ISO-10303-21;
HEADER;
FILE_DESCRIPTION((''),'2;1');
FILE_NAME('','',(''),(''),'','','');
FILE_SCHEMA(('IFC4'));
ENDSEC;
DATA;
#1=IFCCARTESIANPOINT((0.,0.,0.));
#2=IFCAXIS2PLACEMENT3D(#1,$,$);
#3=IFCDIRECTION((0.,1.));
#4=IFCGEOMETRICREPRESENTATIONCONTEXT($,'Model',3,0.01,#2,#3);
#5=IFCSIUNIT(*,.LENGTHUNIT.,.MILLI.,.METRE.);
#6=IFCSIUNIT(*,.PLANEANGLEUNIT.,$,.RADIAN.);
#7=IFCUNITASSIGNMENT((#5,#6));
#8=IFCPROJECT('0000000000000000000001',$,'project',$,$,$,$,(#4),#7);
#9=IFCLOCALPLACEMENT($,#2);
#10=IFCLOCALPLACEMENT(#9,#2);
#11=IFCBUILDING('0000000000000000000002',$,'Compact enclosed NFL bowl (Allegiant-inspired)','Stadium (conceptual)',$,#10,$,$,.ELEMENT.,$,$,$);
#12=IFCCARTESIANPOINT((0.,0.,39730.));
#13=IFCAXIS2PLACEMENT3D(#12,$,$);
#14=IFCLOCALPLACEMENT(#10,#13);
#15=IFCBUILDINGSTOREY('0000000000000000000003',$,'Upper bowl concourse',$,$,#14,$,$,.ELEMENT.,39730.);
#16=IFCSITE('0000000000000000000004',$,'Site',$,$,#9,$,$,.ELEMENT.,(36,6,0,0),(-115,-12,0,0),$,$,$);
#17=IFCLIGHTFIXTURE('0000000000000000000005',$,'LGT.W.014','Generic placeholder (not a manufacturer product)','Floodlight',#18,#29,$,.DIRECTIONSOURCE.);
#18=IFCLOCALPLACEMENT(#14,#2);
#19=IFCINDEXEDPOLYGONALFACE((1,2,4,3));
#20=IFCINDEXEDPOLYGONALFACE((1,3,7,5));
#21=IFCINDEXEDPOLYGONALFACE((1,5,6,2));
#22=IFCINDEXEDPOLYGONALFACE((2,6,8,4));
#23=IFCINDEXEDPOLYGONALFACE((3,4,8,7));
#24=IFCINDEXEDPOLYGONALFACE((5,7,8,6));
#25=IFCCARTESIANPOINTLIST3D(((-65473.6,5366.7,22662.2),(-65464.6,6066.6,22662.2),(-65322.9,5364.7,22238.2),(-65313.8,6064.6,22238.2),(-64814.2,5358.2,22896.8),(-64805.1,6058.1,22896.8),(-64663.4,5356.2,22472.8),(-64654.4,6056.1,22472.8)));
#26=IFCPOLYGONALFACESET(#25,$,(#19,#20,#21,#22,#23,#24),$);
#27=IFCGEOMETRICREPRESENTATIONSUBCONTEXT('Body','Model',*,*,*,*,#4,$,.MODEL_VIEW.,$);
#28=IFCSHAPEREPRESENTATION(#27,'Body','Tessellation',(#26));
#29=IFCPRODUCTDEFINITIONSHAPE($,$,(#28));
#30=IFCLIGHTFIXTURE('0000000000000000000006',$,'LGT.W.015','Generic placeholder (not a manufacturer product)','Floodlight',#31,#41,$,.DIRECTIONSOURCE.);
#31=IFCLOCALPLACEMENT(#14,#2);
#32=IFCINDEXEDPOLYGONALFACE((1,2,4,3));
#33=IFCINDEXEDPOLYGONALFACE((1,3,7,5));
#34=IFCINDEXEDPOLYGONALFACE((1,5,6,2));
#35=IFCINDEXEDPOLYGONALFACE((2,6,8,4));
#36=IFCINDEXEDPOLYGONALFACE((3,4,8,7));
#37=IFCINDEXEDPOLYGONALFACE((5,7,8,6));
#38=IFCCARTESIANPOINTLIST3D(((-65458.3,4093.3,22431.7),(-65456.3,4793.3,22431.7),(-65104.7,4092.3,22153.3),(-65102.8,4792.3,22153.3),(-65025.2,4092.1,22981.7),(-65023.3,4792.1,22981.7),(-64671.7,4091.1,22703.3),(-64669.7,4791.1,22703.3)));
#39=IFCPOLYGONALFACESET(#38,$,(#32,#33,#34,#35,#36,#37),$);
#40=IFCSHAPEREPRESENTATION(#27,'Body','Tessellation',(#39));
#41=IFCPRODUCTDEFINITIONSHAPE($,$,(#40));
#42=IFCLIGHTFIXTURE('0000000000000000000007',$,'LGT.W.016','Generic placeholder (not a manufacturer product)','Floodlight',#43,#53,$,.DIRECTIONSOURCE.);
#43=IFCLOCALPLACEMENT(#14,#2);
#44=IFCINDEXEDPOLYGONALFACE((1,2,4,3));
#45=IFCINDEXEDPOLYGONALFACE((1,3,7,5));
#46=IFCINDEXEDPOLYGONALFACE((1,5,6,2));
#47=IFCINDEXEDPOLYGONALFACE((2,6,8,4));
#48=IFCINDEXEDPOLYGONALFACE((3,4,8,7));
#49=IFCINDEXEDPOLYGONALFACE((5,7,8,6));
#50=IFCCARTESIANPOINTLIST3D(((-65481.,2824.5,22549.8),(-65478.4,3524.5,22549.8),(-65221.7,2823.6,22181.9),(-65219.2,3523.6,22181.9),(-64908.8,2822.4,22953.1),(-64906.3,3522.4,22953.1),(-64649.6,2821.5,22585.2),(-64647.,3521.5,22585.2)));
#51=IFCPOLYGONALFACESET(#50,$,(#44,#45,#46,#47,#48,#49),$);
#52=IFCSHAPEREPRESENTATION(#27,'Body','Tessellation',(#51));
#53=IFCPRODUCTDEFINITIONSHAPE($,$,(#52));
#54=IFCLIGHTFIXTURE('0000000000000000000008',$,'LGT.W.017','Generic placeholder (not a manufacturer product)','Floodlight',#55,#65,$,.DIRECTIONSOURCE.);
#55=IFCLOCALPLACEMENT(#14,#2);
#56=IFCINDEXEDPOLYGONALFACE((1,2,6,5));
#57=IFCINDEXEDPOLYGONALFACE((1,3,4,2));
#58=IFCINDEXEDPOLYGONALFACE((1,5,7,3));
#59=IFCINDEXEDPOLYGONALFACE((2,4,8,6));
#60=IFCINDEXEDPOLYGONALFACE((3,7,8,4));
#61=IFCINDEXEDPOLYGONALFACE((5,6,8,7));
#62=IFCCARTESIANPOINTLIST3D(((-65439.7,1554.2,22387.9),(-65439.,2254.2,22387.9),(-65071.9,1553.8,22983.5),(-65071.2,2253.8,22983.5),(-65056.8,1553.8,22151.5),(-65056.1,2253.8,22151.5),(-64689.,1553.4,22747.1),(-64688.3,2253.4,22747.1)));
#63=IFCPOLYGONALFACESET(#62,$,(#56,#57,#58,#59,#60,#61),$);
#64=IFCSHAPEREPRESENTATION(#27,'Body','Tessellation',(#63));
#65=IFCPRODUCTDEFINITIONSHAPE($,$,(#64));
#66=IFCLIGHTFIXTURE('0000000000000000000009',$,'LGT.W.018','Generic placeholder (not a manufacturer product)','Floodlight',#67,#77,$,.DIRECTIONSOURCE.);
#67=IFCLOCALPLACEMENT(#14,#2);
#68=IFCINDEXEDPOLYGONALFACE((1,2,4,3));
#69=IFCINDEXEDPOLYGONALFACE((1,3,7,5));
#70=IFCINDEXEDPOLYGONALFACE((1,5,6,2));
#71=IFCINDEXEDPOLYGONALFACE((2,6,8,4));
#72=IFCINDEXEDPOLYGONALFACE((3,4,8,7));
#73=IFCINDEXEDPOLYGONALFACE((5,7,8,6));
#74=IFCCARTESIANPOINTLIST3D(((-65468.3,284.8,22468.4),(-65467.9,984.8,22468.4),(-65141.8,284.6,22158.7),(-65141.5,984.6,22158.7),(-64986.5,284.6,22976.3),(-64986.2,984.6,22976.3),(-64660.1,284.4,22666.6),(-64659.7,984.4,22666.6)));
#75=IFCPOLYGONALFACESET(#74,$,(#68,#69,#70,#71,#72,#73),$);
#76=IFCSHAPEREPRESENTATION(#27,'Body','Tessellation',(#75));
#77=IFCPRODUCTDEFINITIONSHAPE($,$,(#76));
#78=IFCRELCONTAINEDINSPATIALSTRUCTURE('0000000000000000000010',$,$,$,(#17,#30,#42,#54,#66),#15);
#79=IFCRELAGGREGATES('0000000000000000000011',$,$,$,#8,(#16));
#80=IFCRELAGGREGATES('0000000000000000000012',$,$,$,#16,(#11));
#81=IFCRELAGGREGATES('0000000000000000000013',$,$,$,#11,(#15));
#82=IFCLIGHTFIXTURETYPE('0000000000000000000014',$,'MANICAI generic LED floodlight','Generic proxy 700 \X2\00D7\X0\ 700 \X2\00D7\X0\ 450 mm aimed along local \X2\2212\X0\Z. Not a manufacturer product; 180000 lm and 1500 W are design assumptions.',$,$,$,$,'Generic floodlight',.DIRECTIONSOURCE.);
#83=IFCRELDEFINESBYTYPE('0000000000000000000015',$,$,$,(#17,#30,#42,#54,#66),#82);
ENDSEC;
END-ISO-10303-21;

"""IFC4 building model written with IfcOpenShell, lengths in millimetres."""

from ifc_helpers import new_model, si_unit, direction, frame, origin, place, context, subcontext, project, spatial, rectangle, extrude, source, transform, mapped, type_object, type_shapes, element, save


model = new_model("IFC4")

# Units and contexts
model_context = context("Model", 3, precision=0.01, world=origin(), true_north=direction((0.0, 1.0)))
body_context = subcontext(model_context, "Body", "Model", "MODEL_VIEW")
ifc_project = project(units=[si_unit("LENGTHUNIT", "METRE", prefix="MILLI"), si_unit("PLANEANGLEUNIT", "RADIAN")], contexts=[model_context])

# Site, building, storey
site_placement = place(None, origin())
site = spatial("IfcSite", under=ifc_project, at=site_placement, Name="Site", CompositionType="ELEMENT", RefLatitude=(36, 6, 0, 0), RefLongitude=(-115, -12, 0, 0))
building_placement = place(site_placement, origin())
building = spatial("IfcBuilding", under=site, at=building_placement, Name="Compact enclosed NFL bowl (Allegiant-inspired)", Description="Stadium (conceptual)", CompositionType="ELEMENT")
storey_placement = place(building_placement, frame((0.0, 0.0, 39730.0)))
storey = spatial("IfcBuildingStorey", under=building, at=storey_placement, Name="Upper bowl concourse", CompositionType="ELEMENT", Elevation=39730.0)

# Light fixtures
light_fixture_type = type_object("IfcLightFixtureType", Name="MANICAI generic LED floodlight", Description="Generic proxy 700 × 700 × 450 mm aimed along local −Z. Not a manufacturer product; 180000 lm and 1500 W are design assumptions.", ElementType="Generic floodlight", PredefinedType="DIRECTIONSOURCE")
shared_shape = source(origin(), body_context, "Body", "SweptSolid", [
    extrude(rectangle(XDim=700.0, YDim=700.0), frame((0.0, 0.0, -225.0)), (0.0, 0.0, 1.0), 450.0),
])
type_shapes(light_fixture_type, [shared_shape])
for number, where, z_axis, x_axis, name in (
    (1, (-65064.0, 5711.4, 22567.5), (-0.335041, 0.004319, 0.942194), (-0.01289, -0.999917, 0.0), "LGT.W.014"),
    (2, (-65064.0, 4442.2, 22567.5), (-0.785672, 0.002206, 0.618639), (-0.002807, -0.999996, 0.0), "LGT.W.015"),
    (3, (-65064.0, 3173.0, 22567.5), (-0.576129, 0.002082, 0.817356), (-0.003613, -0.999993, 0.0), "LGT.W.016"),
    (4, (-65064.0, 1903.8, 22567.5), (-0.850831, 0.000803, 0.52544), (-0.000944, -1.0, 0.0), "LGT.W.017"),
    (5, (-65064.0, 634.6, 22567.5), (-0.725492, 0.000351, 0.688231), (-0.000483, -1.0, 0.0), "LGT.W.018"),
):
    element("IfcLightFixture", number, at=place(storey_placement, frame(where, z_axis=z_axis, x_axis=x_axis)), inside=storey, type_object=light_fixture_type, Name=name, Description="Generic placeholder (not a manufacturer product)", ObjectType="Floodlight", PredefinedType="DIRECTIONSOURCE", context=body_context, shape_type="MappedRepresentation", body=[
        mapped(shared_shape, transform((0.0, 0.0, 0.0))),
    ])

save(model, "model.ifc")
